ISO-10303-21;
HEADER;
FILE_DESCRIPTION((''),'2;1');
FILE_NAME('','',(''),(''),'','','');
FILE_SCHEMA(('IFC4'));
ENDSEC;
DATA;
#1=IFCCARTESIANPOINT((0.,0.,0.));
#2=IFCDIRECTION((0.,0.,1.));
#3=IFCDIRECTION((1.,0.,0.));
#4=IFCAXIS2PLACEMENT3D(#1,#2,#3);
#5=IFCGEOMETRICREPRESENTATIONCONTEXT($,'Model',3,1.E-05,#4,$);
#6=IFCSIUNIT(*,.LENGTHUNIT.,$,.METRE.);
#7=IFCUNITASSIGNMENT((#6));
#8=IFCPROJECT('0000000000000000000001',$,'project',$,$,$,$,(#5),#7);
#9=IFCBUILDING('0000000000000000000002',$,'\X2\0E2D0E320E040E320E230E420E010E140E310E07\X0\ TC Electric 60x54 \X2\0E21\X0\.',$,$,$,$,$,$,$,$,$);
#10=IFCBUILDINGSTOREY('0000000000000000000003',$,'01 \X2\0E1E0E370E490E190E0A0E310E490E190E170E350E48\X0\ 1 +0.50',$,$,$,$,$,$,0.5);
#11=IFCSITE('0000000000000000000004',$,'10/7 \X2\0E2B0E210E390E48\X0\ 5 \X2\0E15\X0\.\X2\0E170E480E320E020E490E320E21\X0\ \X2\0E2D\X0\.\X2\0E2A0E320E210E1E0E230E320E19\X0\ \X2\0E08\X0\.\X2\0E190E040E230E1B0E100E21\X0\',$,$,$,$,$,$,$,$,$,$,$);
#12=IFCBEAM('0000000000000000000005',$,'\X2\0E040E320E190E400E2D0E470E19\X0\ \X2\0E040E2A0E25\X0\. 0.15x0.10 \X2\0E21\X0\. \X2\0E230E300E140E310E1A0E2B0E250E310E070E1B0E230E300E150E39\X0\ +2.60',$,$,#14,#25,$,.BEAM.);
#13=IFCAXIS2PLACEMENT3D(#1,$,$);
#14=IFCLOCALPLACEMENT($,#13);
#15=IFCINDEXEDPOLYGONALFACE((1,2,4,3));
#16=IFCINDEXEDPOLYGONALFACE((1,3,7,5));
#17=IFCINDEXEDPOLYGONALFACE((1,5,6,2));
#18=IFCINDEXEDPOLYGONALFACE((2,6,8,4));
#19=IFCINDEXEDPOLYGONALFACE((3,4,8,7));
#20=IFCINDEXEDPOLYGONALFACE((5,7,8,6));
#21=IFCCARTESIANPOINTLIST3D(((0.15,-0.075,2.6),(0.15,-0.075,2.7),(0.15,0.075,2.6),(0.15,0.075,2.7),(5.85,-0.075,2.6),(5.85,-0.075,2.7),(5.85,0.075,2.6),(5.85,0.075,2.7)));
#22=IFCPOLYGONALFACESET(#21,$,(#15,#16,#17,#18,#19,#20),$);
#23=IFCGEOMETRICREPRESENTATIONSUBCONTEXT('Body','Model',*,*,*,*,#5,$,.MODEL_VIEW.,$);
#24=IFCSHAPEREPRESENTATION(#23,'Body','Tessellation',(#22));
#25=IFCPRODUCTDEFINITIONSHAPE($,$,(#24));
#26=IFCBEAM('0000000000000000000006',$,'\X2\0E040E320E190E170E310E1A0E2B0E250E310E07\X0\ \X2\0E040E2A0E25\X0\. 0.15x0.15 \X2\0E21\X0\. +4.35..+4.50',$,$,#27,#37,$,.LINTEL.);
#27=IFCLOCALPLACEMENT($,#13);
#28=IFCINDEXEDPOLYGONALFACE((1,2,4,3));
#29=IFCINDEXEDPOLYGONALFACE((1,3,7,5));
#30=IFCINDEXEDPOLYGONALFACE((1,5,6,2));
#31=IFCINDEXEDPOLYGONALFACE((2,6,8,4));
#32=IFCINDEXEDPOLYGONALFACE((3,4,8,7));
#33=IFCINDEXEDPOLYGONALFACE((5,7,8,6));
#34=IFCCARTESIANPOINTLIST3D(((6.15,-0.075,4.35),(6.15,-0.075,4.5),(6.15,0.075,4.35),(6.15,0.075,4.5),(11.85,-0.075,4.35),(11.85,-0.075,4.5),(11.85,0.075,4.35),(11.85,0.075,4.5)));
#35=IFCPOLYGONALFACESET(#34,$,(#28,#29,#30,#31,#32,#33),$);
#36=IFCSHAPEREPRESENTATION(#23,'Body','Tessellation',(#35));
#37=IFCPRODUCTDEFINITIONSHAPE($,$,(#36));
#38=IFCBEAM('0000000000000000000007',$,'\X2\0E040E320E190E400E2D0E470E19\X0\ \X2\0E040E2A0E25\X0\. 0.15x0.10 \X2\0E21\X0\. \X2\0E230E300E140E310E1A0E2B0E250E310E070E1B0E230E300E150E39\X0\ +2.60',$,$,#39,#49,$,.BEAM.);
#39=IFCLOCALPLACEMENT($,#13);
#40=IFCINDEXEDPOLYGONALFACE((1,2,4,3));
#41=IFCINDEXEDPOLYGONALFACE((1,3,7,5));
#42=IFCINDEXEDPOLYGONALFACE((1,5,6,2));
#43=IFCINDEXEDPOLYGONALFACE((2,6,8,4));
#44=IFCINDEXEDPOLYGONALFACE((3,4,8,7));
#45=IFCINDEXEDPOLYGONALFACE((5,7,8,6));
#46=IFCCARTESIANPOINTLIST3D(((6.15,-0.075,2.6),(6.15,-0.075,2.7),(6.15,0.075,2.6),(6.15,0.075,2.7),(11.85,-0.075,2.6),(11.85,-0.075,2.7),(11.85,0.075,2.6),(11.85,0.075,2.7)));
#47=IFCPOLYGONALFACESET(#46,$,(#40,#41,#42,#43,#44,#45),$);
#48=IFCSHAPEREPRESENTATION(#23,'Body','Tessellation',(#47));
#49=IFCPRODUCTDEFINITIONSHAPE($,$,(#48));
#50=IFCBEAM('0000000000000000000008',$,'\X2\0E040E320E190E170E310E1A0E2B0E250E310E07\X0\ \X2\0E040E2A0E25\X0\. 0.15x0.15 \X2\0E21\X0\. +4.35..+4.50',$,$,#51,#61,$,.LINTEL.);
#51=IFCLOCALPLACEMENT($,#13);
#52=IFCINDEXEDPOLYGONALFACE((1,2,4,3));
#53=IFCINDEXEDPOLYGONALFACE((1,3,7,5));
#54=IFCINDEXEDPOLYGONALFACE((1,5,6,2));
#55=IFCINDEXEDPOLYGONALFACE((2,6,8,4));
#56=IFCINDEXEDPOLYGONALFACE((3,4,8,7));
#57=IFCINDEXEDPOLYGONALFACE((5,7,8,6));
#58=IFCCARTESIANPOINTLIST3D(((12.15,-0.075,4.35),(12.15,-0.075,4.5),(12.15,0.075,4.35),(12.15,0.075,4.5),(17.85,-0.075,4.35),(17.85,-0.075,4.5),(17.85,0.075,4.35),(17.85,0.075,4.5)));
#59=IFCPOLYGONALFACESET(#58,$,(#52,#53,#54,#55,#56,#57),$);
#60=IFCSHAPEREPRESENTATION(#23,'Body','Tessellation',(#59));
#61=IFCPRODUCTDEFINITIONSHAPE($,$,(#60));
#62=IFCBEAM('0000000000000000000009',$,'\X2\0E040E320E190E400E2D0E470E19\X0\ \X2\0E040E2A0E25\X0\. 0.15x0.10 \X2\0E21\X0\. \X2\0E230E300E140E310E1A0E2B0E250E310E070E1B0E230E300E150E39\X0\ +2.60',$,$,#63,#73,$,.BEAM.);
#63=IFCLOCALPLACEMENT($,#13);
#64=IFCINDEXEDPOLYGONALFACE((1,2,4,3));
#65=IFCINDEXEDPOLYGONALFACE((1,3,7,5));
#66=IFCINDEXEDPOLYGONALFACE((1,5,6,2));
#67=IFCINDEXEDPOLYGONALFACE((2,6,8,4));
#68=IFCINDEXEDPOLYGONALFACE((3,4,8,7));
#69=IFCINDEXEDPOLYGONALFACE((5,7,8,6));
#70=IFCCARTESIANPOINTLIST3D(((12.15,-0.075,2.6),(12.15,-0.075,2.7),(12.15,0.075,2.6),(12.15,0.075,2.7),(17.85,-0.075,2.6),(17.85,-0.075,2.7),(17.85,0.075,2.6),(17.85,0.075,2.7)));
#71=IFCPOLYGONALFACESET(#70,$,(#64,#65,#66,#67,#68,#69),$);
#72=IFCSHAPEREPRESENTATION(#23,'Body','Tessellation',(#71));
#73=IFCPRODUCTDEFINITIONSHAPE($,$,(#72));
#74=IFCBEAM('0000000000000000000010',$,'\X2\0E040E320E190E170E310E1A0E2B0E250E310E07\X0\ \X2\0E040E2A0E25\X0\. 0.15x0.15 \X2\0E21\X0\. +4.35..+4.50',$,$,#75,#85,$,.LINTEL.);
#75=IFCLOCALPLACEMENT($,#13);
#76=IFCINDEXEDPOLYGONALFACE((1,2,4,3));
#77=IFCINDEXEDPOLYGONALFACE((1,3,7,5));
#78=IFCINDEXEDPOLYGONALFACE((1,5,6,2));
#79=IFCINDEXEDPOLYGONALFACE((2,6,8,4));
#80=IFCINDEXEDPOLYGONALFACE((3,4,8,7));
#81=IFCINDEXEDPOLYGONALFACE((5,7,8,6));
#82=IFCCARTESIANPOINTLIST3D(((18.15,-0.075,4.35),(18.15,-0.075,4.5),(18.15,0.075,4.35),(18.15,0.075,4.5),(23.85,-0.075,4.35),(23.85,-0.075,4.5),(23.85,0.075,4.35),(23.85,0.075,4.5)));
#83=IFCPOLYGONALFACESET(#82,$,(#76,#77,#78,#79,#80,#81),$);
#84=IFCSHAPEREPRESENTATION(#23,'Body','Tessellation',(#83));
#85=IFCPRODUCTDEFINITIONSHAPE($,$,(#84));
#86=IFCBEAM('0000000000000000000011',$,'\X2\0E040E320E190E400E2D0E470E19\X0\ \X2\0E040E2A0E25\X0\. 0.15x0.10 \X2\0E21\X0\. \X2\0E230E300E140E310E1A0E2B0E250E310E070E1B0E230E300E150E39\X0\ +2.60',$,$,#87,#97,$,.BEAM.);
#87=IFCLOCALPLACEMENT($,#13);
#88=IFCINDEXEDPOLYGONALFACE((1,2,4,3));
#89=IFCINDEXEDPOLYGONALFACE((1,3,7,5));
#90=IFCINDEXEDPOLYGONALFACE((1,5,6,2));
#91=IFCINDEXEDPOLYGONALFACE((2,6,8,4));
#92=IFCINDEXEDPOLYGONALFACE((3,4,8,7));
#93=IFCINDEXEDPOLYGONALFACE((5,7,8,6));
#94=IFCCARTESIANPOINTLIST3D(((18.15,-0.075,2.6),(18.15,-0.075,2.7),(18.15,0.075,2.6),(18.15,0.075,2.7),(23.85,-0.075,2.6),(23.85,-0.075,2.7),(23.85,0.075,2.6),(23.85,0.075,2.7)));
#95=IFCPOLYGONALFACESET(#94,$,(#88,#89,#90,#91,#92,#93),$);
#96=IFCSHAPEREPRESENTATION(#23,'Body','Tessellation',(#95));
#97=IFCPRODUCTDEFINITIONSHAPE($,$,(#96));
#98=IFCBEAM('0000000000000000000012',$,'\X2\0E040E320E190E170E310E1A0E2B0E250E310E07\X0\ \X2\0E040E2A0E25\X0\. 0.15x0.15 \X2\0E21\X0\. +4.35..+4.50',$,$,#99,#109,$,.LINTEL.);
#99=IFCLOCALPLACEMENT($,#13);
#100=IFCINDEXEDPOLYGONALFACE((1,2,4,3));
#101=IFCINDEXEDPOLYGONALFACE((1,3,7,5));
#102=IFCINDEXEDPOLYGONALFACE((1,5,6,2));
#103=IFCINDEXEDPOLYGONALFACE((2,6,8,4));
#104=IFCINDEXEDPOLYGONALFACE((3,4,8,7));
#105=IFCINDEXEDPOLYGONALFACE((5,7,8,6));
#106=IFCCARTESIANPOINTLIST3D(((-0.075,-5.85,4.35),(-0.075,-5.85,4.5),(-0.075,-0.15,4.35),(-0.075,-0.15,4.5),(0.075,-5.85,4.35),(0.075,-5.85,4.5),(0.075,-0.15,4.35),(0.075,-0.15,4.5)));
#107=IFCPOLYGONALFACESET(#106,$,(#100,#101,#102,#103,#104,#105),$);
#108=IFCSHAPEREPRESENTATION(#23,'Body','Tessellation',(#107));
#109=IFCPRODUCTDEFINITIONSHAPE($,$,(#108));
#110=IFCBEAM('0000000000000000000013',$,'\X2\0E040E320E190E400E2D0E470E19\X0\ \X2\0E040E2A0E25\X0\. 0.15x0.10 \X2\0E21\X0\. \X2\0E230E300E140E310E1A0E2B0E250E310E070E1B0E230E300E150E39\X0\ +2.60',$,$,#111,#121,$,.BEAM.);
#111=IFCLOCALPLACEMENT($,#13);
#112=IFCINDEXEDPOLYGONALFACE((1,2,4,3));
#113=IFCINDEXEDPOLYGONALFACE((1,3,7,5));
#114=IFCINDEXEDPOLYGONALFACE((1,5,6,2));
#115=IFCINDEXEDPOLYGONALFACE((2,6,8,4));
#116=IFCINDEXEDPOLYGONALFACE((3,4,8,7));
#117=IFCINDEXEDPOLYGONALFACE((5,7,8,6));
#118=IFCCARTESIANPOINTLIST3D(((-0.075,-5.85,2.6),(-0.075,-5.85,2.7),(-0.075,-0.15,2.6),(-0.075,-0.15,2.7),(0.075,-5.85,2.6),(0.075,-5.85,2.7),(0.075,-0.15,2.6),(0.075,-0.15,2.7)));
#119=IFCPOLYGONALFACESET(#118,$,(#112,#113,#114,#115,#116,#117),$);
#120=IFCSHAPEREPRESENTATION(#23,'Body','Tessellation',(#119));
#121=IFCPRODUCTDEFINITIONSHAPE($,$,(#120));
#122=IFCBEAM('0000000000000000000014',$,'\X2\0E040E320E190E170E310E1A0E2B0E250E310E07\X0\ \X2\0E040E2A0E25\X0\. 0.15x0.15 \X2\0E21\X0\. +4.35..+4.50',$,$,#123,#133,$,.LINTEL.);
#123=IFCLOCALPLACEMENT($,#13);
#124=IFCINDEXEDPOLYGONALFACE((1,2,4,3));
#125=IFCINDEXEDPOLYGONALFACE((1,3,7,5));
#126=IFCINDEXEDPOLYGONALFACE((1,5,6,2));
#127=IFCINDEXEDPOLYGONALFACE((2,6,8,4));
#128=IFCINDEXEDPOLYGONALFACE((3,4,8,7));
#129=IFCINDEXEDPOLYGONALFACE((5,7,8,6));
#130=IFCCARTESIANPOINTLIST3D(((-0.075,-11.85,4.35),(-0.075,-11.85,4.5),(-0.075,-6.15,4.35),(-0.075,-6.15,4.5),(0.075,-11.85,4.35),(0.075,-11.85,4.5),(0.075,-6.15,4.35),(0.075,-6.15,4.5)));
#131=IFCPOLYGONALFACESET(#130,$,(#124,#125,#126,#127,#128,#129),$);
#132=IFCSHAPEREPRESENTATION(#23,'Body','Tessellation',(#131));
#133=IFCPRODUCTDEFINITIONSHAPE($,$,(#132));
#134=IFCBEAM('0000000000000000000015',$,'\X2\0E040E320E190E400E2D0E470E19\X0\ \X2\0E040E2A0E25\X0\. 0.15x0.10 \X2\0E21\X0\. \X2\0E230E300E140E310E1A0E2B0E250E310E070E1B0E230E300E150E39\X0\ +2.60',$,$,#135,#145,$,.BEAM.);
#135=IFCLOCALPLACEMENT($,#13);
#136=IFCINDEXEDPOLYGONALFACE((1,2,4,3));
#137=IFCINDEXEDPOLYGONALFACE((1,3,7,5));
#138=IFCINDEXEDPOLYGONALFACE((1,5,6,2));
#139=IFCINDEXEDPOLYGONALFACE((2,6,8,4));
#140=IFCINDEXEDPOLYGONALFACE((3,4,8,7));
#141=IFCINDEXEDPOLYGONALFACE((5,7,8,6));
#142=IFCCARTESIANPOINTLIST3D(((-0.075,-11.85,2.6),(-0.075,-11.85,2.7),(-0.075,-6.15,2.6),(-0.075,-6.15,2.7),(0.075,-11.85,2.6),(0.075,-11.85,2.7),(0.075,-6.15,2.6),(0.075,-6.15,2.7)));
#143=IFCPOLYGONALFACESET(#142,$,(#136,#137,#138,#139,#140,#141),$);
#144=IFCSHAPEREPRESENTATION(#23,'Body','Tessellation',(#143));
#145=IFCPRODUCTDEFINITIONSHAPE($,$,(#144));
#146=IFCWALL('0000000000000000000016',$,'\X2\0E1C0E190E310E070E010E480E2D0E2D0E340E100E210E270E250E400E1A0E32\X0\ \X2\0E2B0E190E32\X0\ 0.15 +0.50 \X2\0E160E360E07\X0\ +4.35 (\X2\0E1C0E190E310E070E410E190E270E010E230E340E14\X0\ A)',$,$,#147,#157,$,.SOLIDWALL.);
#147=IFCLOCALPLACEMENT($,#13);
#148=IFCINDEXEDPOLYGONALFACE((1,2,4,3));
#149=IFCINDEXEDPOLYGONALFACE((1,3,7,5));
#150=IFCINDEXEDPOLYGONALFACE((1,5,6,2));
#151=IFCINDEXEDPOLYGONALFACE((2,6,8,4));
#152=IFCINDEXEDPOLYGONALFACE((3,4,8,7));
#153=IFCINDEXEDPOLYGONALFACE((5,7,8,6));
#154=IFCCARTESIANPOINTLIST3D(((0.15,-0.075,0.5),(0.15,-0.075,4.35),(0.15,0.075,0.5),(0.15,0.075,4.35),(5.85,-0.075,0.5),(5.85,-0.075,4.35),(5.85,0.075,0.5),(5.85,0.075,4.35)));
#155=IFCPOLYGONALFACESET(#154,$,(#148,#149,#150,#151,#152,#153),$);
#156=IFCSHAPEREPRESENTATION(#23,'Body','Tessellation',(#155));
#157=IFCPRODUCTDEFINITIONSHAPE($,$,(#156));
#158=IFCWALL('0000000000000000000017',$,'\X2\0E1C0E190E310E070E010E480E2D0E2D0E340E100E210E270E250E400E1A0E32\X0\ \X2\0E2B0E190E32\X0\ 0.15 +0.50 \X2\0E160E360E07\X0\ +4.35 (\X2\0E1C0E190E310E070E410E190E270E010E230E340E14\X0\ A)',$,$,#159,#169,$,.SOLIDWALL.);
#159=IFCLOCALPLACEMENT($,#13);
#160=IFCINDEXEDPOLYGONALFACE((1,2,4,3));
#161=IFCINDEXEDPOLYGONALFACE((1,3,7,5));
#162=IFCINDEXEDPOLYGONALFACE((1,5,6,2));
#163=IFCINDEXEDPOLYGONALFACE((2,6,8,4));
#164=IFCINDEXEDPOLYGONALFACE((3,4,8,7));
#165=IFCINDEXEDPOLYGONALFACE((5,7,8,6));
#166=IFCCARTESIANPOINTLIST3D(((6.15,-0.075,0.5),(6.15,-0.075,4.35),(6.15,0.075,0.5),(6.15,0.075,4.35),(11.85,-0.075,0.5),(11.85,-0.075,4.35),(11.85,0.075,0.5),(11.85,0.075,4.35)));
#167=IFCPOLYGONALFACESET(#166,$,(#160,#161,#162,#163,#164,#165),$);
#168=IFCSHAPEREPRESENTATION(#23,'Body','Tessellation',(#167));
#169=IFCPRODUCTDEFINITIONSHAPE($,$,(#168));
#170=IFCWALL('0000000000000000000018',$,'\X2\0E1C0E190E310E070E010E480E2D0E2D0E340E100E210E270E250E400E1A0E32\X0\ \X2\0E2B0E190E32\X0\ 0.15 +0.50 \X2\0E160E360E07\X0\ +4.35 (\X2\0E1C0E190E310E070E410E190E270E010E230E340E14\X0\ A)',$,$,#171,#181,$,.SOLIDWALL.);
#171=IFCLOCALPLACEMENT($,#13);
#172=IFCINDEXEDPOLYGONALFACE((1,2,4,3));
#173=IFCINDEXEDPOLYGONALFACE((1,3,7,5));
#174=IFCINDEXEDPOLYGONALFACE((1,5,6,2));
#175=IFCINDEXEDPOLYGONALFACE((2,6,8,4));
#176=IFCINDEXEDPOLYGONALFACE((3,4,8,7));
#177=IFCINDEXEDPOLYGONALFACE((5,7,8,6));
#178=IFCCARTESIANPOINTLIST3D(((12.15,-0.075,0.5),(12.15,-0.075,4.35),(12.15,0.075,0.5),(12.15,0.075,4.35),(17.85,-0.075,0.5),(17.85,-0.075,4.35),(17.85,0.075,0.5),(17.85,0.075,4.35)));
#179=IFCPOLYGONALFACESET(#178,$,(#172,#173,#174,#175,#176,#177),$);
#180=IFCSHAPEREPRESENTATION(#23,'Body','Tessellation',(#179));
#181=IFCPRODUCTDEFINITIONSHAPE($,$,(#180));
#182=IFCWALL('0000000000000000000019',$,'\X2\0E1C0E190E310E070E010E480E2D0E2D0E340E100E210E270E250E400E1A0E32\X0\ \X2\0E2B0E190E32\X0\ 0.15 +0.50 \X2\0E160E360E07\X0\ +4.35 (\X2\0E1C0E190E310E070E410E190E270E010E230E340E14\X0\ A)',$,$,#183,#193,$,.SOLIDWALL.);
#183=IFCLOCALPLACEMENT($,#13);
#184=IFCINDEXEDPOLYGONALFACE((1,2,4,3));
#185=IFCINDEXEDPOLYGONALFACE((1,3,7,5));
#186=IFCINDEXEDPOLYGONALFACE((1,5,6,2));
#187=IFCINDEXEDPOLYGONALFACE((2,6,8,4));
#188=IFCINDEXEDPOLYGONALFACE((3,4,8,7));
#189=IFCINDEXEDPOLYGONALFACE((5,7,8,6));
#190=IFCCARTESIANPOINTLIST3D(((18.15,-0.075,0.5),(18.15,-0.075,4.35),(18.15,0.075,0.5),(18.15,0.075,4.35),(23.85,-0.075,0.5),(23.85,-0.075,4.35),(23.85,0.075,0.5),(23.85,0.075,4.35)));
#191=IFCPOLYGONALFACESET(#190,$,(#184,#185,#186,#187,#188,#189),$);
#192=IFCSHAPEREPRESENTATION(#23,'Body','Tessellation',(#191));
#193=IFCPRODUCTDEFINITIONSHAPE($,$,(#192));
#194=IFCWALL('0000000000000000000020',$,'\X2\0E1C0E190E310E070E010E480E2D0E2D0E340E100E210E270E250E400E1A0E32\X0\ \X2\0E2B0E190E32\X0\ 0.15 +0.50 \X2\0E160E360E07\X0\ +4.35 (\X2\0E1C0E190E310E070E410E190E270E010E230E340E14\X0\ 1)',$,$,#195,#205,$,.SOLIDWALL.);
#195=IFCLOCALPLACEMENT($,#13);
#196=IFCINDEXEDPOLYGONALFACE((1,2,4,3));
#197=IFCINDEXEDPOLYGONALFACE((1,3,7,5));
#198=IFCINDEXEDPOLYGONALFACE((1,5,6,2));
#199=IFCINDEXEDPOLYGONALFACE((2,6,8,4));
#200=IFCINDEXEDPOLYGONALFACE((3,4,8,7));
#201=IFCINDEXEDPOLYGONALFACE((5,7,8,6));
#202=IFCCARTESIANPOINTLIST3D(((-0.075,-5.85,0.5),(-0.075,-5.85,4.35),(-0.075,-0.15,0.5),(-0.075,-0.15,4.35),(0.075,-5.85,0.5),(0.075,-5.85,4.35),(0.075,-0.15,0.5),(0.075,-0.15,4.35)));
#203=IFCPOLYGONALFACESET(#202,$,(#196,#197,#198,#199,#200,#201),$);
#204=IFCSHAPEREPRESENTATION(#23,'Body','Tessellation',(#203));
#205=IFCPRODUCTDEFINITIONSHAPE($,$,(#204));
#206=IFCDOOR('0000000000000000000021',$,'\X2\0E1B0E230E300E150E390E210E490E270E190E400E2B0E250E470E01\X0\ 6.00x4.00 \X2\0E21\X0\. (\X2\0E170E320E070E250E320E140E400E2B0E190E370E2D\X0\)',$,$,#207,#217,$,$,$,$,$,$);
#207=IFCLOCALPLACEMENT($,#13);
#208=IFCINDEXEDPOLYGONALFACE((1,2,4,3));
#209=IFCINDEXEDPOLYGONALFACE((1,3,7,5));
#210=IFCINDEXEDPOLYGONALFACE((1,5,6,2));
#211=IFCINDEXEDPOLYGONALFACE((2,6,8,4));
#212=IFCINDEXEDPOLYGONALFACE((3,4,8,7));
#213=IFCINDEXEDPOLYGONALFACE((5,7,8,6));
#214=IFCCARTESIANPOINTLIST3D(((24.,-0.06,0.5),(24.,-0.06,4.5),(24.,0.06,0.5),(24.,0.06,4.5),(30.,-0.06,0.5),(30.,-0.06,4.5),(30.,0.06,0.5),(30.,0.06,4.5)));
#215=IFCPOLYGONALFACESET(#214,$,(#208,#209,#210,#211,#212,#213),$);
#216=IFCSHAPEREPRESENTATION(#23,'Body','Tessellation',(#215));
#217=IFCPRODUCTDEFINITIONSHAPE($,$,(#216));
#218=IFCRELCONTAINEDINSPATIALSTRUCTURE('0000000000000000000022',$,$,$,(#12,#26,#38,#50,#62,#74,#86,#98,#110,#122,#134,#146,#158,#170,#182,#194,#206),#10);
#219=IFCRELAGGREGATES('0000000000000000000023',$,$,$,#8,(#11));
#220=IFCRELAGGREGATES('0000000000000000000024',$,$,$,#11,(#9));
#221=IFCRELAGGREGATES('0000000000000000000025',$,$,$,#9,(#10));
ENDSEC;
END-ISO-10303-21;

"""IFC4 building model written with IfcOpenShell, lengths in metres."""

from ifc_helpers import new_model, si_unit, frame, origin, origin_with_axes, origin_2d, place, context, subcontext, project, spatial, rectangle, extrude, element, save


model = new_model("IFC4")

# Units and contexts
model_context = context("Model", 3, precision=1e-05, world=origin_with_axes())
body_context = subcontext(model_context, "Body", "Model", "MODEL_VIEW")
ifc_project = project(units=[si_unit("LENGTHUNIT", "METRE")], contexts=[model_context])

# Site, building, storey
site = spatial("IfcSite", under=ifc_project, Name="10/7 หมู่ 5 ต.ท่าข้าม อ.สามพราน จ.นครปฐม")
building = spatial("IfcBuilding", under=site, Name="อาคารโกดัง TC Electric 60x54 ม.")
storey = spatial("IfcBuildingStorey", under=building, Name="01 พื้นชั้นที่ 1 +0.50", Elevation=0.5)

# Beams
beam_1_placement = place(None, frame((0.15, 0.0, 2.65), z_axis=(1.0, 0.0, 0.0), x_axis=(0.0, -1.0, 0.0)))
element("IfcBeam", 1, at=beam_1_placement, inside=storey, Name="คานเอ็น คสล. 0.15x0.10 ม. ระดับหลังประตู +2.60", PredefinedType="BEAM", context=body_context, shape_type="SweptSolid", body=[
    extrude(rectangle(XDim=0.15, YDim=0.1, at=origin_2d()), origin(), (0.0, 0.0, 1.0), 5.7),
])
beam_2_placement = place(None, frame((6.15, 0.0, 4.425), z_axis=(1.0, 0.0, 0.0), x_axis=(0.0, -1.0, 0.0)))
element("IfcBeam", 2, at=beam_2_placement, inside=storey, Name="คานทับหลัง คสล. 0.15x0.15 ม. +4.35..+4.50", PredefinedType="LINTEL", context=body_context, shape_type="SweptSolid", body=[
    extrude(rectangle(XDim=0.15, YDim=0.15, at=origin_2d()), origin(), (0.0, 0.0, 1.0), 5.7),
])
beam_3_placement = place(None, frame((6.15, 0.0, 2.65), z_axis=(1.0, 0.0, 0.0), x_axis=(0.0, -1.0, 0.0)))
element("IfcBeam", 3, at=beam_3_placement, inside=storey, Name="คานเอ็น คสล. 0.15x0.10 ม. ระดับหลังประตู +2.60", PredefinedType="BEAM", context=body_context, shape_type="SweptSolid", body=[
    extrude(rectangle(XDim=0.15, YDim=0.1, at=origin_2d()), origin(), (0.0, 0.0, 1.0), 5.7),
])
beam_4_placement = place(None, frame((12.15, 0.0, 4.425), z_axis=(1.0, 0.0, 0.0), x_axis=(0.0, -1.0, 0.0)))
element("IfcBeam", 4, at=beam_4_placement, inside=storey, Name="คานทับหลัง คสล. 0.15x0.15 ม. +4.35..+4.50", PredefinedType="LINTEL", context=body_context, shape_type="SweptSolid", body=[
    extrude(rectangle(XDim=0.15, YDim=0.15, at=origin_2d()), origin(), (0.0, 0.0, 1.0), 5.7),
])
beam_5_placement = place(None, frame((12.15, 0.0, 2.65), z_axis=(1.0, 0.0, 0.0), x_axis=(0.0, -1.0, 0.0)))
element("IfcBeam", 5, at=beam_5_placement, inside=storey, Name="คานเอ็น คสล. 0.15x0.10 ม. ระดับหลังประตู +2.60", PredefinedType="BEAM", context=body_context, shape_type="SweptSolid", body=[
    extrude(rectangle(XDim=0.15, YDim=0.1, at=origin_2d()), origin(), (0.0, 0.0, 1.0), 5.7),
])
beam_6_placement = place(None, frame((18.15, 0.0, 4.425), z_axis=(1.0, 0.0, 0.0), x_axis=(0.0, -1.0, 0.0)))
element("IfcBeam", 6, at=beam_6_placement, inside=storey, Name="คานทับหลัง คสล. 0.15x0.15 ม. +4.35..+4.50", PredefinedType="LINTEL", context=body_context, shape_type="SweptSolid", body=[
    extrude(rectangle(XDim=0.15, YDim=0.15, at=origin_2d()), origin(), (0.0, 0.0, 1.0), 5.7),
])
beam_7_placement = place(None, frame((18.15, 0.0, 2.65), z_axis=(1.0, 0.0, 0.0), x_axis=(0.0, -1.0, 0.0)))
element("IfcBeam", 7, at=beam_7_placement, inside=storey, Name="คานเอ็น คสล. 0.15x0.10 ม. ระดับหลังประตู +2.60", PredefinedType="BEAM", context=body_context, shape_type="SweptSolid", body=[
    extrude(rectangle(XDim=0.15, YDim=0.1, at=origin_2d()), origin(), (0.0, 0.0, 1.0), 5.7),
])
beam_8_placement = place(None, frame((0.0, -0.15, 4.425), z_axis=(0.0, -1.0, 0.0), x_axis=(-1.0, 0.0, 0.0)))
element("IfcBeam", 8, at=beam_8_placement, inside=storey, Name="คานทับหลัง คสล. 0.15x0.15 ม. +4.35..+4.50", PredefinedType="LINTEL", context=body_context, shape_type="SweptSolid", body=[
    extrude(rectangle(XDim=0.15, YDim=0.15, at=origin_2d()), origin(), (0.0, 0.0, 1.0), 5.7),
])
beam_9_placement = place(None, frame((0.0, -0.15, 2.65), z_axis=(0.0, -1.0, 0.0), x_axis=(-1.0, 0.0, 0.0)))
element("IfcBeam", 9, at=beam_9_placement, inside=storey, Name="คานเอ็น คสล. 0.15x0.10 ม. ระดับหลังประตู +2.60", PredefinedType="BEAM", context=body_context, shape_type="SweptSolid", body=[
    extrude(rectangle(XDim=0.15, YDim=0.1, at=origin_2d()), origin(), (0.0, 0.0, 1.0), 5.7),
])
beam_10_placement = place(None, frame((0.0, -6.15, 4.425), z_axis=(0.0, -1.0, 0.0), x_axis=(-1.0, 0.0, 0.0)))
element("IfcBeam", 10, at=beam_10_placement, inside=storey, Name="คานทับหลัง คสล. 0.15x0.15 ม. +4.35..+4.50", PredefinedType="LINTEL", context=body_context, shape_type="SweptSolid", body=[
    extrude(rectangle(XDim=0.15, YDim=0.15, at=origin_2d()), origin(), (0.0, 0.0, 1.0), 5.7),
])
beam_11_placement = place(None, frame((0.0, -6.15, 2.65), z_axis=(0.0, -1.0, 0.0), x_axis=(-1.0, 0.0, 0.0)))
element("IfcBeam", 11, at=beam_11_placement, inside=storey, Name="คานเอ็น คสล. 0.15x0.10 ม. ระดับหลังประตู +2.60", PredefinedType="BEAM", context=body_context, shape_type="SweptSolid", body=[
    extrude(rectangle(XDim=0.15, YDim=0.1, at=origin_2d()), origin(), (0.0, 0.0, 1.0), 5.7),
])

# Walls
for number, where, z_axis, x_axis, name in (
    (12, (3.0, 0.0, 0.5), (0.0, 0.0, 1.0), (1.0, 0.0, 0.0), "ผนังก่ออิฐมวลเบา หนา 0.15 +0.50 ถึง +4.35 (ผนังแนวกริด A)"),
    (13, (9.0, 0.0, 0.5), (0.0, 0.0, 1.0), (1.0, 0.0, 0.0), "ผนังก่ออิฐมวลเบา หนา 0.15 +0.50 ถึง +4.35 (ผนังแนวกริด A)"),
    (14, (15.0, 0.0, 0.5), (0.0, 0.0, 1.0), (1.0, 0.0, 0.0), "ผนังก่ออิฐมวลเบา หนา 0.15 +0.50 ถึง +4.35 (ผนังแนวกริด A)"),
    (15, (21.0, 0.0, 0.5), (0.0, 0.0, 1.0), (1.0, 0.0, 0.0), "ผนังก่ออิฐมวลเบา หนา 0.15 +0.50 ถึง +4.35 (ผนังแนวกริด A)"),
):
    element("IfcWall", number, at=place(None, frame(where, z_axis=z_axis, x_axis=x_axis)), inside=storey, Name=name, PredefinedType="SOLIDWALL", context=body_context, shape_type="SweptSolid", body=[
        extrude(rectangle(XDim=5.7, YDim=0.15, at=origin_2d()), origin(), (0.0, 0.0, 1.0), 3.85),
    ])
wall_placement = place(None, frame((0.0, -3.0, 0.5), z_axis=(0.0, 0.0, 1.0), x_axis=(1.0, 0.0, 0.0)))
element("IfcWall", 16, at=wall_placement, inside=storey, Name="ผนังก่ออิฐมวลเบา หนา 0.15 +0.50 ถึง +4.35 (ผนังแนวกริด 1)", PredefinedType="SOLIDWALL", context=body_context, shape_type="SweptSolid", body=[
    extrude(rectangle(XDim=0.15, YDim=5.7, at=origin_2d()), origin(), (0.0, 0.0, 1.0), 3.85),
])

# Door
door_placement = place(None, frame((27.0, 0.0, 0.5), z_axis=(0.0, 0.0, 1.0), x_axis=(1.0, 0.0, 0.0)))
element("IfcDoor", 17, at=door_placement, inside=storey, Name="ประตูม้วนเหล็ก 6.00x4.00 ม. (ทางลาดเหนือ)", context=body_context, shape_type="SweptSolid", body=[
    extrude(rectangle(XDim=6.0, YDim=0.12, at=origin_2d()), origin(), (0.0, 0.0, 1.0), 4.0),
])

save(model, "model.ifc")
